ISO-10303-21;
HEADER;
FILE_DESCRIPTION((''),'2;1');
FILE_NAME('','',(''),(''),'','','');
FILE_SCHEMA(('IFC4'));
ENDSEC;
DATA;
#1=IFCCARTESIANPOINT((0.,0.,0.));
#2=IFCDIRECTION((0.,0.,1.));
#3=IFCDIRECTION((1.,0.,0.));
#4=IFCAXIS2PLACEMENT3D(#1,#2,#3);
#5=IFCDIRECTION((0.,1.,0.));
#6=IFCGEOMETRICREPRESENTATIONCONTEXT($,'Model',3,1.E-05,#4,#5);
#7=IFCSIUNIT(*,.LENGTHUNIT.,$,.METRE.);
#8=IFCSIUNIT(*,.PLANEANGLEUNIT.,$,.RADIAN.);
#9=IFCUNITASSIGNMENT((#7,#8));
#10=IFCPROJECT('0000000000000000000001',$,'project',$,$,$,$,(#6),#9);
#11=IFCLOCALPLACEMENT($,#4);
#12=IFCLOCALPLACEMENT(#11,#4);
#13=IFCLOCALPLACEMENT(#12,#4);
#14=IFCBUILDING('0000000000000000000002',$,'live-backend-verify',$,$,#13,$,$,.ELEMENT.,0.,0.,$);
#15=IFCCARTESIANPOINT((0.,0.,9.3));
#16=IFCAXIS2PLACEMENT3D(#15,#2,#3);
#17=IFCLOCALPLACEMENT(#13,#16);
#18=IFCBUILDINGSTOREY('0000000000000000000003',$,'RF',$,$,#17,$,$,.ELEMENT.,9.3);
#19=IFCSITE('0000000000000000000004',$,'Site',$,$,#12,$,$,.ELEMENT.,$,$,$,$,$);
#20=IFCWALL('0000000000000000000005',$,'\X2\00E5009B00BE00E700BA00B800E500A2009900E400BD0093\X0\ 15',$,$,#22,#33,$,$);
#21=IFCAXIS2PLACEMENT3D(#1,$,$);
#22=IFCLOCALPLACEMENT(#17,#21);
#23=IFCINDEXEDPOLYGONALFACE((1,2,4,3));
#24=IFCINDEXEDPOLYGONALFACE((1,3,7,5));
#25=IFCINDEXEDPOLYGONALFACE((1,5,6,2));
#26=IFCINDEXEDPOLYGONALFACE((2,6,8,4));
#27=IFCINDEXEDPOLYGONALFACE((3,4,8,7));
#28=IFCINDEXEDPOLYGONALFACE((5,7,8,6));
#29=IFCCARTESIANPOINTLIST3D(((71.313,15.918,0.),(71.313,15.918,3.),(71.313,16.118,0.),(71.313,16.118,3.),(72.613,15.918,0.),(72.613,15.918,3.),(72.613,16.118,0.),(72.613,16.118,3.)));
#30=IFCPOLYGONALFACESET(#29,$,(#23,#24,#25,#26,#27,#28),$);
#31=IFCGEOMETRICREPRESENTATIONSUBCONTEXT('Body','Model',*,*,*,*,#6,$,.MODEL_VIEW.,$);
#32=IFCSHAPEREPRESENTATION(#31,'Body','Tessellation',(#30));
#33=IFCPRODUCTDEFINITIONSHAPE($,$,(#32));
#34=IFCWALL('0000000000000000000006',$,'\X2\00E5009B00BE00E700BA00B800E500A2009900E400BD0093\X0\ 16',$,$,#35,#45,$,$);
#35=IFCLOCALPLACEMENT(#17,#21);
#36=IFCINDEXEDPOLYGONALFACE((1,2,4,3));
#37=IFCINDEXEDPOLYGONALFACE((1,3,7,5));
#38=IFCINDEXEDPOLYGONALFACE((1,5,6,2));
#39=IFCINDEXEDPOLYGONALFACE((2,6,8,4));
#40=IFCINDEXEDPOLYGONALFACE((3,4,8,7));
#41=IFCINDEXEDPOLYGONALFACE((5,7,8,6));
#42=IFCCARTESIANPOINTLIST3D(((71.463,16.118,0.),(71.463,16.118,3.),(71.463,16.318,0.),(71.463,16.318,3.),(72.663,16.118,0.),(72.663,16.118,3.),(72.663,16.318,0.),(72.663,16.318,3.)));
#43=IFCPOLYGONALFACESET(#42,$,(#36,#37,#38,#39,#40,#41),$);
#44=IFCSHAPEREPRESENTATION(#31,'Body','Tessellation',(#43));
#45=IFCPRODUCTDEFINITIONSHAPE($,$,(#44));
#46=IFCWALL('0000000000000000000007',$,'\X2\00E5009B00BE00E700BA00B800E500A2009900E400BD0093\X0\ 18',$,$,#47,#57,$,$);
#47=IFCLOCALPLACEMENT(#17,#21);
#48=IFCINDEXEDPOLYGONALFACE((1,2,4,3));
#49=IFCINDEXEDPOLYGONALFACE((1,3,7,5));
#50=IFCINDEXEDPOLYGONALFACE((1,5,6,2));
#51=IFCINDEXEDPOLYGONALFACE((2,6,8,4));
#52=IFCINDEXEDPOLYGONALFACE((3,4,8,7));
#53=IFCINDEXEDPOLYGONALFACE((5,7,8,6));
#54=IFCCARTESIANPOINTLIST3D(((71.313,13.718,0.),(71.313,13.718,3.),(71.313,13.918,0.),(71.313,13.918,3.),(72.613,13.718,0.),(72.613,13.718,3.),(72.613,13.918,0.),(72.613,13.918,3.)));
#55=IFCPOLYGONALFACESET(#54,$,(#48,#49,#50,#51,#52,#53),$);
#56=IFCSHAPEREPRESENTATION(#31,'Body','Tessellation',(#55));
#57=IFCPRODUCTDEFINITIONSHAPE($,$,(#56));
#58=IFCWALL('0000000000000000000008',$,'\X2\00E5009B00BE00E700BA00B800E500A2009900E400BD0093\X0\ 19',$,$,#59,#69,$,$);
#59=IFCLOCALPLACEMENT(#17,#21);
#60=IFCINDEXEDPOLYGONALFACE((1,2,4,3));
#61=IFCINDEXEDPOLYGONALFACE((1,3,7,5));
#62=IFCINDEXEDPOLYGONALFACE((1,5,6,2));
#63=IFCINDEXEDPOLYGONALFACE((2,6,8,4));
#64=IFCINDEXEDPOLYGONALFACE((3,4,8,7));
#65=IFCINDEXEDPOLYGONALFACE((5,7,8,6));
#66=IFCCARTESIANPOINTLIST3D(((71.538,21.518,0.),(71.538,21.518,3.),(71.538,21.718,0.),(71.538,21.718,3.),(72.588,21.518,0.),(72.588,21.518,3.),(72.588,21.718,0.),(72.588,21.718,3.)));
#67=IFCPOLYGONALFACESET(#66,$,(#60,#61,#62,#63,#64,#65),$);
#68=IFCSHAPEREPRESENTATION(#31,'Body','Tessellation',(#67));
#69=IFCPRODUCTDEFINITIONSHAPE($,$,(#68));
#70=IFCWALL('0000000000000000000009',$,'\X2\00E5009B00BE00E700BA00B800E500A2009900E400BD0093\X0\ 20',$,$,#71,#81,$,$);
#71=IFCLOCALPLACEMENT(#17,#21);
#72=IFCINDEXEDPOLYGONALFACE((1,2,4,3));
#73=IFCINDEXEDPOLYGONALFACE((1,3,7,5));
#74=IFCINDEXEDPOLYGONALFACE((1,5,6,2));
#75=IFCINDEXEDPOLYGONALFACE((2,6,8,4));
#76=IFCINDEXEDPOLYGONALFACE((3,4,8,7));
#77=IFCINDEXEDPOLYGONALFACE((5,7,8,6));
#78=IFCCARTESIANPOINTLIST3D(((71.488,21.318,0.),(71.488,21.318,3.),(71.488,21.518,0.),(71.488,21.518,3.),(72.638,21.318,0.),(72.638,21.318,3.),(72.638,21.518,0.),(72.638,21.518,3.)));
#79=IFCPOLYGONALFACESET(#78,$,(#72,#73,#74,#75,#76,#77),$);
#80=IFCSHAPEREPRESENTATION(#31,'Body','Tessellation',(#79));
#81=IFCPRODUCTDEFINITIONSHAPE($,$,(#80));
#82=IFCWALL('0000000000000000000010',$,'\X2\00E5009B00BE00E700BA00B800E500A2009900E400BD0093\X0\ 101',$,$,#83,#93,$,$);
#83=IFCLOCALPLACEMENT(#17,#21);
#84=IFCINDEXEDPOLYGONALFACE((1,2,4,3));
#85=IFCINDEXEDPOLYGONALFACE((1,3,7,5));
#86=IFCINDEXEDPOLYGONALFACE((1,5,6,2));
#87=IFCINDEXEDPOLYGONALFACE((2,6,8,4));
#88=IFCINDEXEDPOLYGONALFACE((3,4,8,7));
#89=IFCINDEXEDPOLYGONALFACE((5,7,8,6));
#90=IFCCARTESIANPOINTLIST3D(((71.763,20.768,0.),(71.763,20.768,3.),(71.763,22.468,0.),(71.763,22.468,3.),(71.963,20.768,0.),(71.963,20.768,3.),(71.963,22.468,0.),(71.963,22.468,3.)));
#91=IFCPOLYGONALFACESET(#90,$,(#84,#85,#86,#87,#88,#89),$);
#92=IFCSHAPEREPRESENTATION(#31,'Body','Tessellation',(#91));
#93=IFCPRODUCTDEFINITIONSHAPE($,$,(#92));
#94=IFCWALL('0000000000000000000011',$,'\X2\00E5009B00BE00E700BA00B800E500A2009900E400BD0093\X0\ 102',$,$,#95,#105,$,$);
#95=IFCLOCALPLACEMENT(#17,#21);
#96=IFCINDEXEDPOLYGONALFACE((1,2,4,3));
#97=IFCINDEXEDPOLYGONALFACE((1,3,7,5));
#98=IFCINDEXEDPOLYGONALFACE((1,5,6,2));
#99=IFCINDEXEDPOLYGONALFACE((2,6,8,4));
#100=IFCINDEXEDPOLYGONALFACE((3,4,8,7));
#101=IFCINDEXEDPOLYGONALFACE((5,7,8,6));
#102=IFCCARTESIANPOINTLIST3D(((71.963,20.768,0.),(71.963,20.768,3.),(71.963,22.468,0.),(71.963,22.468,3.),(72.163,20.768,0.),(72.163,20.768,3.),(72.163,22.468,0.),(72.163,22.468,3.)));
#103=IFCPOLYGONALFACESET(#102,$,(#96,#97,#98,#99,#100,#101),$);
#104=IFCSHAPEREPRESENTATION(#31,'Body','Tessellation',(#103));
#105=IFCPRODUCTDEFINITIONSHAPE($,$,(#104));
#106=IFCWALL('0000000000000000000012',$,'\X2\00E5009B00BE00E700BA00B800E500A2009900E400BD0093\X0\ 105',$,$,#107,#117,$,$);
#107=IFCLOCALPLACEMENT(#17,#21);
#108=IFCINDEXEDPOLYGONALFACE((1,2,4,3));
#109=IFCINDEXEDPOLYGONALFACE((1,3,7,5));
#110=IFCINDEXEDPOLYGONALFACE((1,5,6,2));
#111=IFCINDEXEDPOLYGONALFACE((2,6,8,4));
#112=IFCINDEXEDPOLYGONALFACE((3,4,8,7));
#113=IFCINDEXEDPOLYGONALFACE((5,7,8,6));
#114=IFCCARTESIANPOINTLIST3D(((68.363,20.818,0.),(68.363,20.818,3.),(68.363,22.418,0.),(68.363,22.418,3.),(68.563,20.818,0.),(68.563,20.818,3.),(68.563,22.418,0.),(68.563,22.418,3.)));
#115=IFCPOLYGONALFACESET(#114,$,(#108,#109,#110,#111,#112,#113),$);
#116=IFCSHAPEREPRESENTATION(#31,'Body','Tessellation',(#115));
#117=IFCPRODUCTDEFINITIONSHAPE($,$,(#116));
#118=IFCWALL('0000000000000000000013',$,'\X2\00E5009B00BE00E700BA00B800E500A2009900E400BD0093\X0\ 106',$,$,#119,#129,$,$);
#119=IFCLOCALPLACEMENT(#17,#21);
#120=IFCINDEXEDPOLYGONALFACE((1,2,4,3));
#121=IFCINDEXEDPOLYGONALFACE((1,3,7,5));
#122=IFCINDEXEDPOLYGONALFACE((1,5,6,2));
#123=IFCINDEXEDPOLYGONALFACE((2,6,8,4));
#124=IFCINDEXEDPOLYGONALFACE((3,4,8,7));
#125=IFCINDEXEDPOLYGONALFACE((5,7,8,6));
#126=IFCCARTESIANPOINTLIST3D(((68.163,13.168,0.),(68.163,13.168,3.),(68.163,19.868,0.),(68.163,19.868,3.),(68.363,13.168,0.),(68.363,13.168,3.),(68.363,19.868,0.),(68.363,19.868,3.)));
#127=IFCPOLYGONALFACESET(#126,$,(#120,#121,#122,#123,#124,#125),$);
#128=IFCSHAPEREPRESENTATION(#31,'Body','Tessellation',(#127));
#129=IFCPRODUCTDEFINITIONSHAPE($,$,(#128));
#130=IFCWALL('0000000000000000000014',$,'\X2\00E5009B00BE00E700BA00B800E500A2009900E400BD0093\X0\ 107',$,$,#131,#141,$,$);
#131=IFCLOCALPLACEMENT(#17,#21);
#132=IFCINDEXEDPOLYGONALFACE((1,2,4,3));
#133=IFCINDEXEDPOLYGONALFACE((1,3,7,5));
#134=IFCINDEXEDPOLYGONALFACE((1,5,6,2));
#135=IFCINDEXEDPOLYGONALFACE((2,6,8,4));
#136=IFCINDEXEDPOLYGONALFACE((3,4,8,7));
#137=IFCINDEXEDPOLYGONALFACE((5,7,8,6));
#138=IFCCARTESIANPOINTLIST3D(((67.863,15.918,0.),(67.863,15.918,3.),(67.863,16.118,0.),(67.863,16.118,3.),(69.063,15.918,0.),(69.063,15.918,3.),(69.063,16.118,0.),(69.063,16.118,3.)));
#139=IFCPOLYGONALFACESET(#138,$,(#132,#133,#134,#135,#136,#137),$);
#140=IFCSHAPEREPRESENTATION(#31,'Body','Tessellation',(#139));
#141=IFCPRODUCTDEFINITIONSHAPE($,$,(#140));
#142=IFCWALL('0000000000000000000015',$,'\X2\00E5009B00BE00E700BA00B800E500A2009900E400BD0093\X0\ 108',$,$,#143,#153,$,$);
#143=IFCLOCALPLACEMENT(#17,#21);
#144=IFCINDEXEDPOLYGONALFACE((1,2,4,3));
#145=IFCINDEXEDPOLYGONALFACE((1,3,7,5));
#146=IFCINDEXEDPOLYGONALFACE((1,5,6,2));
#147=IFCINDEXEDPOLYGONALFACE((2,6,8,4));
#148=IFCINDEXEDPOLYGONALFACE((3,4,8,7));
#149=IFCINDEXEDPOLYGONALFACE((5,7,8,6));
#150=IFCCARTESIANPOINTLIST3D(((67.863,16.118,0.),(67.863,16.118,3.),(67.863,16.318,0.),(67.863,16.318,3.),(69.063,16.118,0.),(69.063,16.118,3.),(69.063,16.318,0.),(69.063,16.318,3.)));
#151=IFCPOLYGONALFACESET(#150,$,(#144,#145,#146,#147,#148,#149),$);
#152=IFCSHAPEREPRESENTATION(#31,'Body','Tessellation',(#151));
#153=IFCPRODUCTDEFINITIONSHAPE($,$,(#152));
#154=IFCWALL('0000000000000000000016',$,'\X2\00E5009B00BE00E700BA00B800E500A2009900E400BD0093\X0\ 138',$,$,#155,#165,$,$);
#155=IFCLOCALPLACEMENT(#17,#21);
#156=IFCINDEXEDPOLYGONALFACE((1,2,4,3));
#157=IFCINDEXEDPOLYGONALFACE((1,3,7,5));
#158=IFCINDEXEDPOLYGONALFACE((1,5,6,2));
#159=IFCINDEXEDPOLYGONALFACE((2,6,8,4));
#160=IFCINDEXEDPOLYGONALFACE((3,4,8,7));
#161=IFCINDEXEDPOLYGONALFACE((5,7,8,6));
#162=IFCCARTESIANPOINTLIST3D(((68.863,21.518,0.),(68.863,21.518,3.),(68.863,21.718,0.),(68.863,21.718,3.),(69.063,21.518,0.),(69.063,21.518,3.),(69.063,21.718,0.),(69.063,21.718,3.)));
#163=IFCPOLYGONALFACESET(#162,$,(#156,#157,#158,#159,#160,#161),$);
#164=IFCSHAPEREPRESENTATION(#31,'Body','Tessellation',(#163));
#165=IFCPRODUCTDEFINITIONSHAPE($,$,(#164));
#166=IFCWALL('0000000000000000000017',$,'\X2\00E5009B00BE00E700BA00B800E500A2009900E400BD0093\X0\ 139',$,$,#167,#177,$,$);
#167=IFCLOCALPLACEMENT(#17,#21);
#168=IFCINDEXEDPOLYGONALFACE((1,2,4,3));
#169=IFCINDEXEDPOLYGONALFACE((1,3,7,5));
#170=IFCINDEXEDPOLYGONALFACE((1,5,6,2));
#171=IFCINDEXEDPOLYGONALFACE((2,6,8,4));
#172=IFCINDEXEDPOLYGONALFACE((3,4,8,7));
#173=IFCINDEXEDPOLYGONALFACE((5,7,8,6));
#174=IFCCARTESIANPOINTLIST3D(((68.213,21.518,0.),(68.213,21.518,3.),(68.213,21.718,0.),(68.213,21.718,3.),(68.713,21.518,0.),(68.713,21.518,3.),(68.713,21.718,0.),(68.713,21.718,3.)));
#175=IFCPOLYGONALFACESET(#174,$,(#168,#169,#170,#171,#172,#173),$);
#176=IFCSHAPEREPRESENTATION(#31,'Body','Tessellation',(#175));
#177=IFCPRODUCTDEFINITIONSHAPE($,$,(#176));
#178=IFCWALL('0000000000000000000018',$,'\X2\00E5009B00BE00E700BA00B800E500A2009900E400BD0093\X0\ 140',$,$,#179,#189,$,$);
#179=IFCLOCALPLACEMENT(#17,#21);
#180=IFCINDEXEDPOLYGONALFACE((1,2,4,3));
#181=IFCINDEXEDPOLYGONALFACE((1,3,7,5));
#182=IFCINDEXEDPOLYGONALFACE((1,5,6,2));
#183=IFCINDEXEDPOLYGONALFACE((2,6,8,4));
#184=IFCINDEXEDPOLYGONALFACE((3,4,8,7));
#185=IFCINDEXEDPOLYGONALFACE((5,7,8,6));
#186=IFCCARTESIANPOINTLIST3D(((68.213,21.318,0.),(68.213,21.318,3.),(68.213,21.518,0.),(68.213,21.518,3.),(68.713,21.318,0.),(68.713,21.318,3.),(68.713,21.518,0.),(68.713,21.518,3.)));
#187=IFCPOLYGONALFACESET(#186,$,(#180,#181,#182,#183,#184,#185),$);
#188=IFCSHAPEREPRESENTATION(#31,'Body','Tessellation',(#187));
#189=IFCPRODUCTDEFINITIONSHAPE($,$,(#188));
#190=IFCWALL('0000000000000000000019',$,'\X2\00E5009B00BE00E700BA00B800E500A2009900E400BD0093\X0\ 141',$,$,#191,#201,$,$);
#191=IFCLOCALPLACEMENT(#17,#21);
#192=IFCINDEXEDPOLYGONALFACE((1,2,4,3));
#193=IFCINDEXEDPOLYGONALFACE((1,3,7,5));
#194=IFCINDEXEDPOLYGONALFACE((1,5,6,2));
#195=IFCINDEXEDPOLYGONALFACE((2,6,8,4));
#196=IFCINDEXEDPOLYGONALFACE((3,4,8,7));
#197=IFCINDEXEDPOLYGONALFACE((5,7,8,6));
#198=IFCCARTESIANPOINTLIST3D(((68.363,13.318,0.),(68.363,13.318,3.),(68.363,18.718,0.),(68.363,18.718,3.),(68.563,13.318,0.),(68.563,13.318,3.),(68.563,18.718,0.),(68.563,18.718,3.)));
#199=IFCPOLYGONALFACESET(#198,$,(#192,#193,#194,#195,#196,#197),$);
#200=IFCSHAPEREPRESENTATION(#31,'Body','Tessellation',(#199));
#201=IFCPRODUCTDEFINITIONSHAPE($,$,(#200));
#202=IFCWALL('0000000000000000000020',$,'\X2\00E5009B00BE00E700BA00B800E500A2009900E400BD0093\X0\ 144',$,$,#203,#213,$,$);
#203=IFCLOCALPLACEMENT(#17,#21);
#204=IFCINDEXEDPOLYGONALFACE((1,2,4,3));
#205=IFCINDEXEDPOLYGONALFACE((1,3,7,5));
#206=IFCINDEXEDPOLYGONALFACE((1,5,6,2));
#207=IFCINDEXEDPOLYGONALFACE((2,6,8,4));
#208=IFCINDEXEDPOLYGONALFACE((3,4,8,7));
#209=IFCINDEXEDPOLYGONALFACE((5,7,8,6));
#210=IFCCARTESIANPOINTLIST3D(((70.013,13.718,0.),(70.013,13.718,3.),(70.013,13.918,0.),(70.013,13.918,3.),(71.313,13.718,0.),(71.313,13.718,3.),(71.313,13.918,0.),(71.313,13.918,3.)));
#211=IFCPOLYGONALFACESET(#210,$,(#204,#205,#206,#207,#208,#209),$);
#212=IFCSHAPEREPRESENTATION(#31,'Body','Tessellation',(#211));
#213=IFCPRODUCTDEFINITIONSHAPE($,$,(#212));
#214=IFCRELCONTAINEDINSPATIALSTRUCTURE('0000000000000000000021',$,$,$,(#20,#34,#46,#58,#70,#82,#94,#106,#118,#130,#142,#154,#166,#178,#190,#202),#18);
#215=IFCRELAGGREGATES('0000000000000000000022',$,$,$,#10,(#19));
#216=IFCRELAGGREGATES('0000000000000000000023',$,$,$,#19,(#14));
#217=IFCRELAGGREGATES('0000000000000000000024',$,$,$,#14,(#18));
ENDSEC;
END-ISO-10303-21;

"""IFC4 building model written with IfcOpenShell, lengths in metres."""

from ifc_helpers import new_model, si_unit, direction, frame, frame_2d, origin_with_axes, place, context, subcontext, project, spatial, rectangle, extrude, element, save


model = new_model("IFC4")

# Units and contexts
model_context = context("Model", 3, precision=1e-05, world=origin_with_axes(), true_north=direction((0.0, 1.0, 0.0)))
body_context = subcontext(model_context, "Body", "Model", "MODEL_VIEW")
ifc_project = project(units=[si_unit("LENGTHUNIT", "METRE"), si_unit("PLANEANGLEUNIT", "RADIAN")], contexts=[model_context])

# Site, building, storey
placement = place(None, origin_with_axes())
site_placement = place(placement, origin_with_axes())
site = spatial("IfcSite", under=ifc_project, at=site_placement, Name="Site", CompositionType="ELEMENT")
building_placement = place(site_placement, origin_with_axes())
building = spatial("IfcBuilding", under=site, at=building_placement, Name="live-backend-verify", CompositionType="ELEMENT", ElevationOfRefHeight=0.0, ElevationOfTerrain=0.0)
storey_placement = place(building_placement, frame((0.0, 0.0, 9.3), z_axis=(0.0, 0.0, 1.0), x_axis=(1.0, 0.0, 0.0)))
storey = spatial("IfcBuildingStorey", under=building, at=storey_placement, Name="RF", CompositionType="ELEMENT", Elevation=9.3)

# Walls
wall_1_placement = place(storey_placement, frame((71.963, 16.018, 0.0), z_axis=(0.0, 0.0, 1.0), x_axis=(1.0, 0.0, 0.0)))
element("IfcWall", 1, at=wall_1_placement, inside=storey, Name="å\u009b¾çº¸å¢\u0099ä½\u0093 15", context=body_context, shape_type="SweptSolid", body=[
    extrude(rectangle(XDim=1.3, YDim=0.2, at=frame_2d((0.0, 0.0), x_axis=(1.0, 0.0, 0.0))), frame((0.0, 0.0, 0.0), z_axis=(0.0, 0.0, 1.0)), (0.0, 0.0, 1.0), 3.0),
])
wall_2_placement = place(storey_placement, frame((72.063, 16.218, 0.0), z_axis=(0.0, 0.0, 1.0), x_axis=(1.0, 0.0, 0.0)))
element("IfcWall", 2, at=wall_2_placement, inside=storey, Name="å\u009b¾çº¸å¢\u0099ä½\u0093 16", context=body_context, shape_type="SweptSolid", body=[
    extrude(rectangle(XDim=1.2, YDim=0.2, at=frame_2d((0.0, 0.0), x_axis=(1.0, 0.0, 0.0))), frame((0.0, 0.0, 0.0), z_axis=(0.0, 0.0, 1.0)), (0.0, 0.0, 1.0), 3.0),
])
wall_3_placement = place(storey_placement, frame((71.963, 13.818, 0.0), z_axis=(0.0, 0.0, 1.0), x_axis=(1.0, 0.0, 0.0)))
element("IfcWall", 3, at=wall_3_placement, inside=storey, Name="å\u009b¾çº¸å¢\u0099ä½\u0093 18", context=body_context, shape_type="SweptSolid", body=[
    extrude(rectangle(XDim=1.3, YDim=0.2, at=frame_2d((0.0, 0.0), x_axis=(1.0, 0.0, 0.0))), frame((0.0, 0.0, 0.0), z_axis=(0.0, 0.0, 1.0)), (0.0, 0.0, 1.0), 3.0),
])
wall_4_placement = place(storey_placement, frame((72.063, 21.618, 0.0), z_axis=(0.0, 0.0, 1.0), x_axis=(1.0, 0.0, 0.0)))
element("IfcWall", 4, at=wall_4_placement, inside=storey, Name="å\u009b¾çº¸å¢\u0099ä½\u0093 19", context=body_context, shape_type="SweptSolid", body=[
    extrude(rectangle(XDim=1.05, YDim=0.2, at=frame_2d((0.0, 0.0), x_axis=(1.0, 0.0, 0.0))), frame((0.0, 0.0, 0.0), z_axis=(0.0, 0.0, 1.0)), (0.0, 0.0, 1.0), 3.0),
])
wall_5_placement = place(storey_placement, frame((72.063, 21.418, 0.0), z_axis=(0.0, 0.0, 1.0), x_axis=(1.0, 0.0, 0.0)))
element("IfcWall", 5, at=wall_5_placement, inside=storey, Name="å\u009b¾çº¸å¢\u0099ä½\u0093 20", context=body_context, shape_type="SweptSolid", body=[
    extrude(rectangle(XDim=1.15, YDim=0.2, at=frame_2d((0.0, 0.0), x_axis=(1.0, 0.0, 0.0))), frame((0.0, 0.0, 0.0), z_axis=(0.0, 0.0, 1.0)), (0.0, 0.0, 1.0), 3.0),
])
for number, where, z_axis, x_axis, name in (
    (6, (71.863, 21.618, 0.0), (0.0, 0.0, 1.0), (0.0, 1.0, 0.0), "å\u009b¾çº¸å¢\u0099ä½\u0093 101"),
    (7, (72.063, 21.618, 0.0), (0.0, 0.0, 1.0), (0.0, 1.0, 0.0), "å\u009b¾çº¸å¢\u0099ä½\u0093 102"),
):
    element("IfcWall", number, at=place(storey_placement, frame(where, z_axis=z_axis, x_axis=x_axis)), inside=storey, Name=name, context=body_context, shape_type="SweptSolid", body=[
        extrude(rectangle(XDim=1.7, YDim=0.2, at=frame_2d((0.0, 0.0), x_axis=(1.0, 0.0, 0.0))), frame((0.0, 0.0, 0.0), z_axis=(0.0, 0.0, 1.0)), (0.0, 0.0, 1.0), 3.0),
    ])
wall_6_placement = place(storey_placement, frame((68.463, 21.618, 0.0), z_axis=(0.0, 0.0, 1.0), x_axis=(0.0, 1.0, 0.0)))
element("IfcWall", 8, at=wall_6_placement, inside=storey, Name="å\u009b¾çº¸å¢\u0099ä½\u0093 105", context=body_context, shape_type="SweptSolid", body=[
    extrude(rectangle(XDim=1.6, YDim=0.2, at=frame_2d((0.0, 0.0), x_axis=(1.0, 0.0, 0.0))), frame((0.0, 0.0, 0.0), z_axis=(0.0, 0.0, 1.0)), (0.0, 0.0, 1.0), 3.0),
])
wall_7_placement = place(storey_placement, frame((68.263, 16.518, 0.0), z_axis=(0.0, 0.0, 1.0), x_axis=(0.0, 1.0, 0.0)))
element("IfcWall", 9, at=wall_7_placement, inside=storey, Name="å\u009b¾çº¸å¢\u0099ä½\u0093 106", context=body_context, shape_type="SweptSolid", body=[
    extrude(rectangle(XDim=6.7, YDim=0.2, at=frame_2d((0.0, 0.0), x_axis=(1.0, 0.0, 0.0))), frame((0.0, 0.0, 0.0), z_axis=(0.0, 0.0, 1.0)), (0.0, 0.0, 1.0), 3.0),
])
for number, where, z_axis, x_axis, name in (
    (10, (68.463, 16.018, 0.0), (0.0, 0.0, 1.0), (1.0, 0.0, 0.0), "å\u009b¾çº¸å¢\u0099ä½\u0093 107"),
    (11, (68.463, 16.218, 0.0), (0.0, 0.0, 1.0), (1.0, 0.0, 0.0), "å\u009b¾çº¸å¢\u0099ä½\u0093 108"),
):
    element("IfcWall", number, at=place(storey_placement, frame(where, z_axis=z_axis, x_axis=x_axis)), inside=storey, Name=name, context=body_context, shape_type="SweptSolid", body=[
        extrude(rectangle(XDim=1.2, YDim=0.2, at=frame_2d((0.0, 0.0), x_axis=(1.0, 0.0, 0.0))), frame((0.0, 0.0, 0.0), z_axis=(0.0, 0.0, 1.0)), (0.0, 0.0, 1.0), 3.0),
    ])
wall_8_placement = place(storey_placement, frame((68.963, 21.618, 0.0), z_axis=(0.0, 0.0, 1.0), x_axis=(0.0, -1.0, 0.0)))
element("IfcWall", 12, at=wall_8_placement, inside=storey, Name="å\u009b¾çº¸å¢\u0099ä½\u0093 138", context=body_context, shape_type="SweptSolid", body=[
    extrude(rectangle(XDim=0.2, YDim=0.2, at=frame_2d((0.0, 0.0), x_axis=(1.0, 0.0, 0.0))), frame((0.0, 0.0, 0.0), z_axis=(0.0, 0.0, 1.0)), (0.0, 0.0, 1.0), 3.0),
])
for number, where, z_axis, x_axis, name in (
    (13, (68.463, 21.618, 0.0), (0.0, 0.0, 1.0), (1.0, 0.0, 0.0), "å\u009b¾çº¸å¢\u0099ä½\u0093 139"),
    (14, (68.463, 21.418, 0.0), (0.0, 0.0, 1.0), (1.0, 0.0, 0.0), "å\u009b¾çº¸å¢\u0099ä½\u0093 140"),
):
    element("IfcWall", number, at=place(storey_placement, frame(where, z_axis=z_axis, x_axis=x_axis)), inside=storey, Name=name, context=body_context, shape_type="SweptSolid", body=[
        extrude(rectangle(XDim=0.5, YDim=0.2, at=frame_2d((0.0, 0.0), x_axis=(1.0, 0.0, 0.0))), frame((0.0, 0.0, 0.0), z_axis=(0.0, 0.0, 1.0)), (0.0, 0.0, 1.0), 3.0),
    ])
wall_9_placement = place(storey_placement, frame((68.463, 16.018, 0.0), z_axis=(0.0, 0.0, 1.0), x_axis=(0.0, 1.0, 0.0)))
element("IfcWall", 15, at=wall_9_placement, inside=storey, Name="å\u009b¾çº¸å¢\u0099ä½\u0093 141", context=body_context, shape_type="SweptSolid", body=[
    extrude(rectangle(XDim=5.4, YDim=0.2, at=frame_2d((0.0, 0.0), x_axis=(1.0, 0.0, 0.0))), frame((0.0, 0.0, 0.0), z_axis=(0.0, 0.0, 1.0)), (0.0, 0.0, 1.0), 3.0),
])
wall_10_placement = place(storey_placement, frame((70.663, 13.818, 0.0), z_axis=(0.0, 0.0, 1.0), x_axis=(1.0, 0.0, 0.0)))
element("IfcWall", 16, at=wall_10_placement, inside=storey, Name="å\u009b¾çº¸å¢\u0099ä½\u0093 144", context=body_context, shape_type="SweptSolid", body=[
    extrude(rectangle(XDim=1.3, YDim=0.2, at=frame_2d((0.0, 0.0), x_axis=(1.0, 0.0, 0.0))), frame((0.0, 0.0, 0.0), z_axis=(0.0, 0.0, 1.0)), (0.0, 0.0, 1.0), 3.0),
])

save(model, "model.ifc")
